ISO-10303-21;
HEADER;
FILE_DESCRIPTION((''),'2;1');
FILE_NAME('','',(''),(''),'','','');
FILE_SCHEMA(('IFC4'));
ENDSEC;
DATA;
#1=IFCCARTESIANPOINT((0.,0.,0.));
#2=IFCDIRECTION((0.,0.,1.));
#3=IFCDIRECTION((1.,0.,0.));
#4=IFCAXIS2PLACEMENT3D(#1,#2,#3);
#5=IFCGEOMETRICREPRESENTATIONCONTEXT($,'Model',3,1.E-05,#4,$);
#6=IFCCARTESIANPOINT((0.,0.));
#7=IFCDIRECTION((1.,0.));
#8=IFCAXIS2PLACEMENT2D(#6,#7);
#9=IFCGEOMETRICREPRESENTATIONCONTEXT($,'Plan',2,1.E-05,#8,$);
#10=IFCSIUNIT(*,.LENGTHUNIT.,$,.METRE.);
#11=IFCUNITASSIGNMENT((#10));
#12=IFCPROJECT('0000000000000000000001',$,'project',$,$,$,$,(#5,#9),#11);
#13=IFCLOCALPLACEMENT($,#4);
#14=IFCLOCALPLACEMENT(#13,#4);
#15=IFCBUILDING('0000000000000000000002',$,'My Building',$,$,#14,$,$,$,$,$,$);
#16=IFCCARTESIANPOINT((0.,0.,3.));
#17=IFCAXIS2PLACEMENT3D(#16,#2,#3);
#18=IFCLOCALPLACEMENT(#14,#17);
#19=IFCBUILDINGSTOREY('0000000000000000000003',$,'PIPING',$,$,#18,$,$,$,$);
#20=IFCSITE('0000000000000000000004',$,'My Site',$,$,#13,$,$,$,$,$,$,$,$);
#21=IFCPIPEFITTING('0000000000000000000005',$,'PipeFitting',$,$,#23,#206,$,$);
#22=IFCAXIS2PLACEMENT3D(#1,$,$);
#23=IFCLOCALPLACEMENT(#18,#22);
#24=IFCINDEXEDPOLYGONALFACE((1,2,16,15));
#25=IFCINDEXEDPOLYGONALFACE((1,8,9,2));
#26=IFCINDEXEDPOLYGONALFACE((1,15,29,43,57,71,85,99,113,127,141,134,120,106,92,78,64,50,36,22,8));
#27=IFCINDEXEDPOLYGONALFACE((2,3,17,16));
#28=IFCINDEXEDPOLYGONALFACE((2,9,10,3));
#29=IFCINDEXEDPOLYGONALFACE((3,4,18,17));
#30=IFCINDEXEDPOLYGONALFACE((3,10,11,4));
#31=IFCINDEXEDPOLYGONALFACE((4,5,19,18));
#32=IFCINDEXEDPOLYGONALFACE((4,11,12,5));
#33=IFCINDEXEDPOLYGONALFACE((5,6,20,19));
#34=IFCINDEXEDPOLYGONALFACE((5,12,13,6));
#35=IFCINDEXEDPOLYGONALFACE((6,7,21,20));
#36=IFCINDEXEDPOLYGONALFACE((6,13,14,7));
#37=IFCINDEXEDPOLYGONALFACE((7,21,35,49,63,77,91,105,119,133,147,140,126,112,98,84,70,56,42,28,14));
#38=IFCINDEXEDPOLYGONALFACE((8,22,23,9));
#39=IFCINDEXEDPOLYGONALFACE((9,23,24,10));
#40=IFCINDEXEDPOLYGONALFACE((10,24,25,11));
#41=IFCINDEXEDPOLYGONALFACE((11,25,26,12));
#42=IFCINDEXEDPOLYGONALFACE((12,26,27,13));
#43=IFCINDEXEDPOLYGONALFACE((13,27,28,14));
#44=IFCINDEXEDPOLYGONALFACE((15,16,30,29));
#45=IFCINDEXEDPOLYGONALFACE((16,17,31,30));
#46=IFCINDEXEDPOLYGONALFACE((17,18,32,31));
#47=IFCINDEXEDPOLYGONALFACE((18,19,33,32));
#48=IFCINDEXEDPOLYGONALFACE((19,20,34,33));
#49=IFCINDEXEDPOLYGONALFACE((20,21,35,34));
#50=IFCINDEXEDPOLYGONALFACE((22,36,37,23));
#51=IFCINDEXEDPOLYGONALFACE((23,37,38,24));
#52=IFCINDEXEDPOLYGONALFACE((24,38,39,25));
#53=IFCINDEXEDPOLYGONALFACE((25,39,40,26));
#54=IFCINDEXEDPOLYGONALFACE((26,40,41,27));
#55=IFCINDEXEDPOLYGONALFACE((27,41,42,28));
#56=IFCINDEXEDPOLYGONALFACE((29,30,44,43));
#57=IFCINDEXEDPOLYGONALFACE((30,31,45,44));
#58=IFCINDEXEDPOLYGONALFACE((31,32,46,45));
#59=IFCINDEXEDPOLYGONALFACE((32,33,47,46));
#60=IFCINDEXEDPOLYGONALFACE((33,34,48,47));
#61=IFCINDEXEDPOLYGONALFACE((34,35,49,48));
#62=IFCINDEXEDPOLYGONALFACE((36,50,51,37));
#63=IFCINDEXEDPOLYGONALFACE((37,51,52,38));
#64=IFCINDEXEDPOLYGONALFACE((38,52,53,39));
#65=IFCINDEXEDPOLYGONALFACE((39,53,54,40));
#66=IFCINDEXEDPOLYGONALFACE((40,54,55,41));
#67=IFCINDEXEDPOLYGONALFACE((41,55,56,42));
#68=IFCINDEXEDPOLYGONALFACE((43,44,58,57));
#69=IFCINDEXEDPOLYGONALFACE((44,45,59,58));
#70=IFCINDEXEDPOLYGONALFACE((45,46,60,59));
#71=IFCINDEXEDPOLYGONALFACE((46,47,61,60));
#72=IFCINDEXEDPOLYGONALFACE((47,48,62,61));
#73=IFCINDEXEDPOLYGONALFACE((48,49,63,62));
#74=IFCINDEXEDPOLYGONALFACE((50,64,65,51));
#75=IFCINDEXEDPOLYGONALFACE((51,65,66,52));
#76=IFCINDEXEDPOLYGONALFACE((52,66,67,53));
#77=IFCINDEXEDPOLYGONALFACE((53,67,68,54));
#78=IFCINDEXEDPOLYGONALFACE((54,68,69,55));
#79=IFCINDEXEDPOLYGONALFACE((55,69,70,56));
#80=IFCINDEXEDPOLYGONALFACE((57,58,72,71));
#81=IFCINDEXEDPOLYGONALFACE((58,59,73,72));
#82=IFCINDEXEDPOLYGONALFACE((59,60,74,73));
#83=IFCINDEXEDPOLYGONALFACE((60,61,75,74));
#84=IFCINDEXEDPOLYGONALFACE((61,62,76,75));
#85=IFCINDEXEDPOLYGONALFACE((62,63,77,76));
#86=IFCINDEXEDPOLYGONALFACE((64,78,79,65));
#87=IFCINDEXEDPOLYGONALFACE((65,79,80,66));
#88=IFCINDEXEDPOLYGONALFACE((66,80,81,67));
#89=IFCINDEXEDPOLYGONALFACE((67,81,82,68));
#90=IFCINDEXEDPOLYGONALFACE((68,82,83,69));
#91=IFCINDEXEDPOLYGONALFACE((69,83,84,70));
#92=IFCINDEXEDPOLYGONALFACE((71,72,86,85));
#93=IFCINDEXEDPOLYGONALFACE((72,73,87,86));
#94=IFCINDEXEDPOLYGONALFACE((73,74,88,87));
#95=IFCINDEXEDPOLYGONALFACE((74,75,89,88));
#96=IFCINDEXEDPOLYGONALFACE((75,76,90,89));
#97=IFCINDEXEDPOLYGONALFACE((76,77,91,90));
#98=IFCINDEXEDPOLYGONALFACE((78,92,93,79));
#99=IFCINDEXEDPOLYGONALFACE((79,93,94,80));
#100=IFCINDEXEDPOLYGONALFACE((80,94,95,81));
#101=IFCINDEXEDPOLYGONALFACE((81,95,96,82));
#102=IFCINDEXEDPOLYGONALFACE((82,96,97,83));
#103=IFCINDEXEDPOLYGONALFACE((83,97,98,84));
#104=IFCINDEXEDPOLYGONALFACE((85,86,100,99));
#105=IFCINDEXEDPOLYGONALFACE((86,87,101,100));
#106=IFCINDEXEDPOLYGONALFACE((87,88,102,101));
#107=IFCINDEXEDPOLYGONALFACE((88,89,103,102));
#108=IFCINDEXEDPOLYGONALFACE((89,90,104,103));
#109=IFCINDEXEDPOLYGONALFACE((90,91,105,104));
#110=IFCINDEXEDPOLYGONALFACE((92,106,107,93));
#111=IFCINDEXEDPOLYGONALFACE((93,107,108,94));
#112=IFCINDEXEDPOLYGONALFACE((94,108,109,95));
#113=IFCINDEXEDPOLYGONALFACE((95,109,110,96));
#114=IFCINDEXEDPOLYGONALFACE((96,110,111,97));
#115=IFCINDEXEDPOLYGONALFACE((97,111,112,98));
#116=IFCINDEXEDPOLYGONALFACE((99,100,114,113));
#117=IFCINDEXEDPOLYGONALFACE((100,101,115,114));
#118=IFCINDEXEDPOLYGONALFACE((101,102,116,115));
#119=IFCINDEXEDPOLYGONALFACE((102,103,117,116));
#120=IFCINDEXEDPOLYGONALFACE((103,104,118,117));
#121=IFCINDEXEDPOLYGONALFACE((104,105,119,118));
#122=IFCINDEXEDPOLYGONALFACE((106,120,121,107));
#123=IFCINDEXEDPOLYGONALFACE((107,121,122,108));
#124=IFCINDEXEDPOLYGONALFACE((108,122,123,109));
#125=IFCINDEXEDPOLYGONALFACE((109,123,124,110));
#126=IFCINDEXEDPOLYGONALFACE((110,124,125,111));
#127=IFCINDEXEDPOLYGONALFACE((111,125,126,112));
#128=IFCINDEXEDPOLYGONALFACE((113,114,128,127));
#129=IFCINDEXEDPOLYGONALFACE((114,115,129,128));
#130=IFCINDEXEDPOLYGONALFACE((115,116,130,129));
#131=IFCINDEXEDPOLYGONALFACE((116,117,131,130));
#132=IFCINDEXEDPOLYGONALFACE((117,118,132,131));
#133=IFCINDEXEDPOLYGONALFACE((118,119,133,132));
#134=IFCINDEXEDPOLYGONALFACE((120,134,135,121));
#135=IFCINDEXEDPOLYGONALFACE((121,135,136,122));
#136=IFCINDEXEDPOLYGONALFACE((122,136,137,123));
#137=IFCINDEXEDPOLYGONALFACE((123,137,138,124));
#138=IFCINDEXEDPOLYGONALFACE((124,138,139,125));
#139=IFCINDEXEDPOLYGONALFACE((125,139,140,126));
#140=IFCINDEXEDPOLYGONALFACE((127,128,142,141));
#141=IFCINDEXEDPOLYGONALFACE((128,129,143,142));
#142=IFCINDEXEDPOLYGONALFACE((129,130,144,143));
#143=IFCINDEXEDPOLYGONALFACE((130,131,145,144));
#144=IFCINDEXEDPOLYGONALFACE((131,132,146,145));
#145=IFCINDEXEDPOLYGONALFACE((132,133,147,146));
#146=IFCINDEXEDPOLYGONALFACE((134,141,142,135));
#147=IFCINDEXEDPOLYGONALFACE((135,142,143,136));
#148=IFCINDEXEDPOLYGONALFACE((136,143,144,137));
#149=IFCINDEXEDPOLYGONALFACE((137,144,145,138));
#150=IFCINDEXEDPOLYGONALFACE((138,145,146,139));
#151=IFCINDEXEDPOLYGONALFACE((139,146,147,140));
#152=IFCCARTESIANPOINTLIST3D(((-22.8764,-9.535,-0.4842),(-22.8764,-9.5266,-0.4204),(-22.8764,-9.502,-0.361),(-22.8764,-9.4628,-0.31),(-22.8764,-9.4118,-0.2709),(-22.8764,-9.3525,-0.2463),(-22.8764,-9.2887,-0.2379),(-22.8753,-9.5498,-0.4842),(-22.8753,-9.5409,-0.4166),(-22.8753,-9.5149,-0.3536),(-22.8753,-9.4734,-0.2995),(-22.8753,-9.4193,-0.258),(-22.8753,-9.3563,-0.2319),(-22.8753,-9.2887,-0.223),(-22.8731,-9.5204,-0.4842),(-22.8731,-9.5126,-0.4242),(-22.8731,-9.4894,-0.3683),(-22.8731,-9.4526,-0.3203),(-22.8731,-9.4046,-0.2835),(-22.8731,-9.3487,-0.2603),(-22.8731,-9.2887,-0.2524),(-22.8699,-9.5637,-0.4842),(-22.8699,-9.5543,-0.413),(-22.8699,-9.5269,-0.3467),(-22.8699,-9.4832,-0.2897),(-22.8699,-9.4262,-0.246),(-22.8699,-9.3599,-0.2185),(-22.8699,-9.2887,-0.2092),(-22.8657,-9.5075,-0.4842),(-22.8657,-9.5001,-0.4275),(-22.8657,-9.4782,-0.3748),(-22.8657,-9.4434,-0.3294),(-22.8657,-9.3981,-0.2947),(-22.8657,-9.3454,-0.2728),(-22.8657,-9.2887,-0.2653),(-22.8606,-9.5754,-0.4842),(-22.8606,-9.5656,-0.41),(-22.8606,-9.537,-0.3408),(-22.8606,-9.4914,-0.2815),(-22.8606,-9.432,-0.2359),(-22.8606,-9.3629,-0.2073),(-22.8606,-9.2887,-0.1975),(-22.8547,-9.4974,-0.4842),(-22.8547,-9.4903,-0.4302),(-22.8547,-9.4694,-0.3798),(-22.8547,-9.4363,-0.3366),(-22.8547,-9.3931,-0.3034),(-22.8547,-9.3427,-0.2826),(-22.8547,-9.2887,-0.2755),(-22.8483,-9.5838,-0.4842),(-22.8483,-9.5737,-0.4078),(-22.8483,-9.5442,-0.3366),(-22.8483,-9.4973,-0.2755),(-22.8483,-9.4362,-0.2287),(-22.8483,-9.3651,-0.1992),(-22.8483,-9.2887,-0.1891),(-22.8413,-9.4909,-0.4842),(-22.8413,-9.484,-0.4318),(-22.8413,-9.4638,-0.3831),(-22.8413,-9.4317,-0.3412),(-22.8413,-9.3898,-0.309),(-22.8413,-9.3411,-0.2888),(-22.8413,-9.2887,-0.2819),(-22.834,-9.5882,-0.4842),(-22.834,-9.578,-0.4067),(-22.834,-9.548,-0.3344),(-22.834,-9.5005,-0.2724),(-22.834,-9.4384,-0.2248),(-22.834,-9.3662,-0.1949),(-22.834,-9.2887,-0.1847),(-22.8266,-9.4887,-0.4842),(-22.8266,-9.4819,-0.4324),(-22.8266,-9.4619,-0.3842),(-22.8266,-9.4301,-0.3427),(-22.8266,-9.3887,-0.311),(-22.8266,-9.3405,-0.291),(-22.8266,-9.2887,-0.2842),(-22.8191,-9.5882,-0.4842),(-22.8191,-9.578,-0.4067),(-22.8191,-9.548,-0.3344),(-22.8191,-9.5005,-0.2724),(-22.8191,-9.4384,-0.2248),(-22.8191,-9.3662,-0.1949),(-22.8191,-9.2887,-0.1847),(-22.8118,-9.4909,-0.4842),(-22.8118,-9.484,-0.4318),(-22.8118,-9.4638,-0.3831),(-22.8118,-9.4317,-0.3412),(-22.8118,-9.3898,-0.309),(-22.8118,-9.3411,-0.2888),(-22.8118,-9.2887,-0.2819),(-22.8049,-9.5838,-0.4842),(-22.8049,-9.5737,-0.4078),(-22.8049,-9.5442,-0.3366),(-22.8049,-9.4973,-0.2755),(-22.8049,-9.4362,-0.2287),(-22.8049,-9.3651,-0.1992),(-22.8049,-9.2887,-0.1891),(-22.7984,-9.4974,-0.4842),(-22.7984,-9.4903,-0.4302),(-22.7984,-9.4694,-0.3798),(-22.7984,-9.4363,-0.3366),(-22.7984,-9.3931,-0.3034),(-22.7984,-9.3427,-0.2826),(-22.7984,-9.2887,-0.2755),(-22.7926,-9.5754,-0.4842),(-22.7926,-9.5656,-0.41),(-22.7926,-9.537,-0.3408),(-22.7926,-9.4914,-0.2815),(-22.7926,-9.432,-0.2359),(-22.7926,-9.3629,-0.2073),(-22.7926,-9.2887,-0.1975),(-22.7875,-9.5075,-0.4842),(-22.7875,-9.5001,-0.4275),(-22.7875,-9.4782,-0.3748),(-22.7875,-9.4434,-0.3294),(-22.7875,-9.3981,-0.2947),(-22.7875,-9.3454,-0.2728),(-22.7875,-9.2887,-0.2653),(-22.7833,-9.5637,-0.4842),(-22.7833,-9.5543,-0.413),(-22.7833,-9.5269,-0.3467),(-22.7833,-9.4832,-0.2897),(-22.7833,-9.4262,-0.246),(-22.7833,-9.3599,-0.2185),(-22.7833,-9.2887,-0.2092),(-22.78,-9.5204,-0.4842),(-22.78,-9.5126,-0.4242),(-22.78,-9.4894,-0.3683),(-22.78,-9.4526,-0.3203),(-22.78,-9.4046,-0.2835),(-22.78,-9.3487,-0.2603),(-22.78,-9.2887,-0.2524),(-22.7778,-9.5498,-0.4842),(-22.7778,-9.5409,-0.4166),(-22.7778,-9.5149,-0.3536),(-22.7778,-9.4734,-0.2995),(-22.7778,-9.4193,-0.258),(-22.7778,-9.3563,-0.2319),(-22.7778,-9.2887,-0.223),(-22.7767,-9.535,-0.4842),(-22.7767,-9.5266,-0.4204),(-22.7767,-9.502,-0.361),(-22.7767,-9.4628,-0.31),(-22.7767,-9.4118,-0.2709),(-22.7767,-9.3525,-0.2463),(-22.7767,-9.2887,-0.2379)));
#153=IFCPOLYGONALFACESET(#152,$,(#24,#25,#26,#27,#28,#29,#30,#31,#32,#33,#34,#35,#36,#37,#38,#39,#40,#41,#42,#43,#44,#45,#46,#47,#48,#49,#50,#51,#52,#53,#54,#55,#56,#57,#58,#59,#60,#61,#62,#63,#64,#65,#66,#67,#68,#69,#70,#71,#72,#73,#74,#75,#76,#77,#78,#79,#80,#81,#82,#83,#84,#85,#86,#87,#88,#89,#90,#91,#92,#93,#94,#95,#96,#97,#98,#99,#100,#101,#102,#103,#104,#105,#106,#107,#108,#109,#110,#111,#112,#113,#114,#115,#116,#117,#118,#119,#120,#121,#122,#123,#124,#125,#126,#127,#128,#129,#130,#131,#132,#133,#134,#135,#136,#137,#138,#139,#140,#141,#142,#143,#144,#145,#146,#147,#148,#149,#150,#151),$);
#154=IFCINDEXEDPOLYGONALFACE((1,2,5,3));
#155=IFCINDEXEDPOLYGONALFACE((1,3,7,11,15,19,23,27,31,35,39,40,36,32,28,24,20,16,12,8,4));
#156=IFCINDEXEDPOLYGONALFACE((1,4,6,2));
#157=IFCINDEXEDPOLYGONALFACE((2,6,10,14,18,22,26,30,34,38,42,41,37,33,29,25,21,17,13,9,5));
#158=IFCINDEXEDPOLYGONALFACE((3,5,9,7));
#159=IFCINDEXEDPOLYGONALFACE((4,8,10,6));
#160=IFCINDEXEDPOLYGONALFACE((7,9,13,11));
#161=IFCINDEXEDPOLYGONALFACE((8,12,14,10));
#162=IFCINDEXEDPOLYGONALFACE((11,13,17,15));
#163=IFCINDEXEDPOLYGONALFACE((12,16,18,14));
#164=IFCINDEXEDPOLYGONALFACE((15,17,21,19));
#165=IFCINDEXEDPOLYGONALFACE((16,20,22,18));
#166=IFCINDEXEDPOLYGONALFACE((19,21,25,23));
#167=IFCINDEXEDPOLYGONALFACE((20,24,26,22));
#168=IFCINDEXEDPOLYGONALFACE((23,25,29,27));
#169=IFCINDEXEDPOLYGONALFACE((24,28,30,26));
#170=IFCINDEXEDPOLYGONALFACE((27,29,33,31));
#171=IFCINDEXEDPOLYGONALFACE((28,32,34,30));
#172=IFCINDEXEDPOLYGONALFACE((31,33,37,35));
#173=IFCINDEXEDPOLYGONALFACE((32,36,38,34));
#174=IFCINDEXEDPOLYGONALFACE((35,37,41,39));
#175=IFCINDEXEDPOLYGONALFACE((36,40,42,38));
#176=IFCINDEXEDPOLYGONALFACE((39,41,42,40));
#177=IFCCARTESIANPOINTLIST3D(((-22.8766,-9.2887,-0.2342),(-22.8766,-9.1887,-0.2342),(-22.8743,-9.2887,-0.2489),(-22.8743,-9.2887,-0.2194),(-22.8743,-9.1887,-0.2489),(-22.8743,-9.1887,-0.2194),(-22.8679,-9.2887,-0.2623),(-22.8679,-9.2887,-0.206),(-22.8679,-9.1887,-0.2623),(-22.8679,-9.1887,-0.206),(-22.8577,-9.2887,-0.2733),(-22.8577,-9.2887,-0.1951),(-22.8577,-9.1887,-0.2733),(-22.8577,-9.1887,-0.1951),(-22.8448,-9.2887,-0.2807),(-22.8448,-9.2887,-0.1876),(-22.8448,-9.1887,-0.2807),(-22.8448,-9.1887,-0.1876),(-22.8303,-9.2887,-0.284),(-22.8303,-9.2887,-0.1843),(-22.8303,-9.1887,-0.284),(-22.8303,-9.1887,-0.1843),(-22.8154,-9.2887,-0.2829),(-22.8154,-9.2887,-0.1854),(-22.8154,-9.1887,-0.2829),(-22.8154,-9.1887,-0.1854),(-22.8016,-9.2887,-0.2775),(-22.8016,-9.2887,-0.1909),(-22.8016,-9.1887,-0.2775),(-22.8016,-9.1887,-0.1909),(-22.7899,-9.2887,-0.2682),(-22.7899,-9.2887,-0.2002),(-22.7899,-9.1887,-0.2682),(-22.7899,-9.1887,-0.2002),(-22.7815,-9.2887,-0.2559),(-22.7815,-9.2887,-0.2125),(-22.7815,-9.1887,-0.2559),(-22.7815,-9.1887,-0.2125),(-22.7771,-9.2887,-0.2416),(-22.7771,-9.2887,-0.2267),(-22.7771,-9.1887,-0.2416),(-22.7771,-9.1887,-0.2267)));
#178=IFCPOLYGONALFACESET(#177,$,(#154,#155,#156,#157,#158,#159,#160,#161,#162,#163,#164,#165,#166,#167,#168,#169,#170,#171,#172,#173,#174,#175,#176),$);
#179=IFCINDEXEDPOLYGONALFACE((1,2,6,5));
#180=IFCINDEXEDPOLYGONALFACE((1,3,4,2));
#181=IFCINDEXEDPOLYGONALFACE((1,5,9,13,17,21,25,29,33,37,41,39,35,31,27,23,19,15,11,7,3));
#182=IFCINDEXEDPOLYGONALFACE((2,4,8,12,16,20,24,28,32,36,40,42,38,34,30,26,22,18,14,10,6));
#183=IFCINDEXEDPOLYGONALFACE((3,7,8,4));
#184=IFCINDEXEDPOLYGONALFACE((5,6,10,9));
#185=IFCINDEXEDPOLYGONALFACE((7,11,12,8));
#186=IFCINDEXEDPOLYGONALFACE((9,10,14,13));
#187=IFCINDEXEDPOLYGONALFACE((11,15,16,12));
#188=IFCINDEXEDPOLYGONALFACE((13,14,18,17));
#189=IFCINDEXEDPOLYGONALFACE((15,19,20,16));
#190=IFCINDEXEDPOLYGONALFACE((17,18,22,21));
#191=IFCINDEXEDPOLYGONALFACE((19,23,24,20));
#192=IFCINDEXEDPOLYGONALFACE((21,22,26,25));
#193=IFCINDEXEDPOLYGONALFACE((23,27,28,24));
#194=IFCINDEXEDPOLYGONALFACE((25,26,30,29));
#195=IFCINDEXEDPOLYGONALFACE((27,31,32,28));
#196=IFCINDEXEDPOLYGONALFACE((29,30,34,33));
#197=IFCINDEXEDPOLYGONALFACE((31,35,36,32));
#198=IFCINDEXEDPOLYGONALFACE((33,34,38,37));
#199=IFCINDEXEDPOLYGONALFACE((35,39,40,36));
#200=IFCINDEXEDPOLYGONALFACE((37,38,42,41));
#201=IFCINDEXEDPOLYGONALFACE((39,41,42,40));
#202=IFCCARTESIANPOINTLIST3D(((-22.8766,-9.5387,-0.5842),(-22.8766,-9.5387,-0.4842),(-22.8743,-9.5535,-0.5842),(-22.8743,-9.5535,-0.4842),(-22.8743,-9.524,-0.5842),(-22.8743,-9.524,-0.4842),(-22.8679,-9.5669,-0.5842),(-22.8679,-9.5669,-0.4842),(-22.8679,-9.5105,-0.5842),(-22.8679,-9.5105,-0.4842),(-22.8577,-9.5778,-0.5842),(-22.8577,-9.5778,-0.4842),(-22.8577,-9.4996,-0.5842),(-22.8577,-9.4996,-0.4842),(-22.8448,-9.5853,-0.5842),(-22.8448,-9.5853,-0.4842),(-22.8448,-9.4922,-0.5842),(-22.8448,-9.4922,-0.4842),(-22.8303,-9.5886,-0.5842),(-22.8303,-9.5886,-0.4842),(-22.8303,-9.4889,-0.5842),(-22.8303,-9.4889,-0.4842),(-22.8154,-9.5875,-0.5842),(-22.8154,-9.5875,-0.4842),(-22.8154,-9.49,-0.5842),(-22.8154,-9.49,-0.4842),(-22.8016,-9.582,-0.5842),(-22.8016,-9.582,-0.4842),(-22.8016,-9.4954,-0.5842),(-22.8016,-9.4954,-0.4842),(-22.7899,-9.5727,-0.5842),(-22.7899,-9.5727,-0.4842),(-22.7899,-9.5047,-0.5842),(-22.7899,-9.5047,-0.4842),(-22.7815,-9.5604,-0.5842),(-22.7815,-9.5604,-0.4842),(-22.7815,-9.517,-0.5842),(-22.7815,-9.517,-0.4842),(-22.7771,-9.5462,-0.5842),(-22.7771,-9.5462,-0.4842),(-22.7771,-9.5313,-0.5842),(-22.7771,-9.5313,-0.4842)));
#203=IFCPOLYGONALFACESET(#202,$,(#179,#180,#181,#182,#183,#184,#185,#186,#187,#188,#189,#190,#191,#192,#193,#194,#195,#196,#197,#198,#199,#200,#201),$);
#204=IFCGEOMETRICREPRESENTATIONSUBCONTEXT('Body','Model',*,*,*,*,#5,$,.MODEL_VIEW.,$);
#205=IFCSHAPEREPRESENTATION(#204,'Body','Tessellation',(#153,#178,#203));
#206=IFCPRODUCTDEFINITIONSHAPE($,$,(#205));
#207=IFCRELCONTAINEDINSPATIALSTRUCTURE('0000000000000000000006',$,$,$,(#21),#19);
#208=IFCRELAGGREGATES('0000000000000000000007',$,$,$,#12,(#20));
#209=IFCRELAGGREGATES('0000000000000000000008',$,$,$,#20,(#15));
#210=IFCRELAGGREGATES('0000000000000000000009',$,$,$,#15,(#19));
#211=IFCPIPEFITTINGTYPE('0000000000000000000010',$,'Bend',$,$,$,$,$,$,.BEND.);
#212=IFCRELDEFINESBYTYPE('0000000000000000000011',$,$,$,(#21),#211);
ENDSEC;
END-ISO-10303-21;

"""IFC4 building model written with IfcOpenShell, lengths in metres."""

from ifc_helpers import new_model, entity, si_unit, frame, origin_with_axes, origin_2d_with_axis, place, context, subcontext, project, spatial, circle, extrude, source, transform, mapped, type_object, type_shapes, element, save


model = new_model("IFC4")

# Units and contexts
model_context = context("Model", 3, precision=1e-05, world=origin_with_axes())
plan_context = context("Plan", 2, precision=1e-05, world=origin_2d_with_axis())
body_context = subcontext(model_context, "Body", "Model", "MODEL_VIEW")
ifc_project = project(units=[si_unit("LENGTHUNIT", "METRE")], contexts=[model_context, plan_context])

# Site, building, storey
site_placement = place(None, origin_with_axes())
site = spatial("IfcSite", under=ifc_project, at=site_placement, Name="My Site")
building_placement = place(site_placement, origin_with_axes())
building = spatial("IfcBuilding", under=site, at=building_placement, Name="My Building")
storey_placement = place(building_placement, frame((0.0, 0.0, 3.0), z_axis=(0.0, 0.0, 1.0), x_axis=(1.0, 0.0, 0.0)))
storey = spatial("IfcBuildingStorey", under=building, at=storey_placement, Name="PIPING")

# Pipe fitting
pipe_fitting_type = type_object("IfcPipeFittingType", Name="Bend", PredefinedType="BEND")
shared_shape = source(origin_with_axes(), body_context, "Body", "SolidModel", [
    entity("IfcSweptDiskSolid", entity("IfcIndexedPolyCurve", entity("IfcCartesianPointList3D", [[0.0, 0.0, -0.1], [0.0, -0.0732, -0.2768], [0.0, -0.25, -0.35]]), [entity("IfcArcIndex", [1, 2, 3])]), 0.05),
    extrude(circle(Radius=0.05), origin_with_axes(), (0.0, 0.0, -1.0), 0.1),
    extrude(circle(Radius=0.05), frame((0.0, -0.25, -0.35), z_axis=(0.0, -1.0, 0.0), x_axis=(1.0, 0.0, 0.0)), (0.0, 0.0, 1.0), 0.1),
])
type_shapes(pipe_fitting_type, [shared_shape])
for number, where, z_axis, x_axis, name in (
    (1, (-22.8266, -9.1887, -0.2342), (0.0, 1.0, 0.0), (-1.0, 0.0, 0.0), "PipeFitting"),
):
    element("IfcPipeFitting", number, at=place(storey_placement, frame(where, z_axis=z_axis, x_axis=x_axis)), inside=storey, type_object=pipe_fitting_type, Name=name, context=body_context, shape_type="MappedRepresentation", body=[
        mapped(shared_shape, transform((0.0, 0.0, 0.0), x_axis=(1.0, 0.0, 0.0), y_axis=(0.0, 1.0, 0.0), z_axis=(0.0, 0.0, 1.0), scale=1.0)),
    ])

save(model, "model.ifc")
